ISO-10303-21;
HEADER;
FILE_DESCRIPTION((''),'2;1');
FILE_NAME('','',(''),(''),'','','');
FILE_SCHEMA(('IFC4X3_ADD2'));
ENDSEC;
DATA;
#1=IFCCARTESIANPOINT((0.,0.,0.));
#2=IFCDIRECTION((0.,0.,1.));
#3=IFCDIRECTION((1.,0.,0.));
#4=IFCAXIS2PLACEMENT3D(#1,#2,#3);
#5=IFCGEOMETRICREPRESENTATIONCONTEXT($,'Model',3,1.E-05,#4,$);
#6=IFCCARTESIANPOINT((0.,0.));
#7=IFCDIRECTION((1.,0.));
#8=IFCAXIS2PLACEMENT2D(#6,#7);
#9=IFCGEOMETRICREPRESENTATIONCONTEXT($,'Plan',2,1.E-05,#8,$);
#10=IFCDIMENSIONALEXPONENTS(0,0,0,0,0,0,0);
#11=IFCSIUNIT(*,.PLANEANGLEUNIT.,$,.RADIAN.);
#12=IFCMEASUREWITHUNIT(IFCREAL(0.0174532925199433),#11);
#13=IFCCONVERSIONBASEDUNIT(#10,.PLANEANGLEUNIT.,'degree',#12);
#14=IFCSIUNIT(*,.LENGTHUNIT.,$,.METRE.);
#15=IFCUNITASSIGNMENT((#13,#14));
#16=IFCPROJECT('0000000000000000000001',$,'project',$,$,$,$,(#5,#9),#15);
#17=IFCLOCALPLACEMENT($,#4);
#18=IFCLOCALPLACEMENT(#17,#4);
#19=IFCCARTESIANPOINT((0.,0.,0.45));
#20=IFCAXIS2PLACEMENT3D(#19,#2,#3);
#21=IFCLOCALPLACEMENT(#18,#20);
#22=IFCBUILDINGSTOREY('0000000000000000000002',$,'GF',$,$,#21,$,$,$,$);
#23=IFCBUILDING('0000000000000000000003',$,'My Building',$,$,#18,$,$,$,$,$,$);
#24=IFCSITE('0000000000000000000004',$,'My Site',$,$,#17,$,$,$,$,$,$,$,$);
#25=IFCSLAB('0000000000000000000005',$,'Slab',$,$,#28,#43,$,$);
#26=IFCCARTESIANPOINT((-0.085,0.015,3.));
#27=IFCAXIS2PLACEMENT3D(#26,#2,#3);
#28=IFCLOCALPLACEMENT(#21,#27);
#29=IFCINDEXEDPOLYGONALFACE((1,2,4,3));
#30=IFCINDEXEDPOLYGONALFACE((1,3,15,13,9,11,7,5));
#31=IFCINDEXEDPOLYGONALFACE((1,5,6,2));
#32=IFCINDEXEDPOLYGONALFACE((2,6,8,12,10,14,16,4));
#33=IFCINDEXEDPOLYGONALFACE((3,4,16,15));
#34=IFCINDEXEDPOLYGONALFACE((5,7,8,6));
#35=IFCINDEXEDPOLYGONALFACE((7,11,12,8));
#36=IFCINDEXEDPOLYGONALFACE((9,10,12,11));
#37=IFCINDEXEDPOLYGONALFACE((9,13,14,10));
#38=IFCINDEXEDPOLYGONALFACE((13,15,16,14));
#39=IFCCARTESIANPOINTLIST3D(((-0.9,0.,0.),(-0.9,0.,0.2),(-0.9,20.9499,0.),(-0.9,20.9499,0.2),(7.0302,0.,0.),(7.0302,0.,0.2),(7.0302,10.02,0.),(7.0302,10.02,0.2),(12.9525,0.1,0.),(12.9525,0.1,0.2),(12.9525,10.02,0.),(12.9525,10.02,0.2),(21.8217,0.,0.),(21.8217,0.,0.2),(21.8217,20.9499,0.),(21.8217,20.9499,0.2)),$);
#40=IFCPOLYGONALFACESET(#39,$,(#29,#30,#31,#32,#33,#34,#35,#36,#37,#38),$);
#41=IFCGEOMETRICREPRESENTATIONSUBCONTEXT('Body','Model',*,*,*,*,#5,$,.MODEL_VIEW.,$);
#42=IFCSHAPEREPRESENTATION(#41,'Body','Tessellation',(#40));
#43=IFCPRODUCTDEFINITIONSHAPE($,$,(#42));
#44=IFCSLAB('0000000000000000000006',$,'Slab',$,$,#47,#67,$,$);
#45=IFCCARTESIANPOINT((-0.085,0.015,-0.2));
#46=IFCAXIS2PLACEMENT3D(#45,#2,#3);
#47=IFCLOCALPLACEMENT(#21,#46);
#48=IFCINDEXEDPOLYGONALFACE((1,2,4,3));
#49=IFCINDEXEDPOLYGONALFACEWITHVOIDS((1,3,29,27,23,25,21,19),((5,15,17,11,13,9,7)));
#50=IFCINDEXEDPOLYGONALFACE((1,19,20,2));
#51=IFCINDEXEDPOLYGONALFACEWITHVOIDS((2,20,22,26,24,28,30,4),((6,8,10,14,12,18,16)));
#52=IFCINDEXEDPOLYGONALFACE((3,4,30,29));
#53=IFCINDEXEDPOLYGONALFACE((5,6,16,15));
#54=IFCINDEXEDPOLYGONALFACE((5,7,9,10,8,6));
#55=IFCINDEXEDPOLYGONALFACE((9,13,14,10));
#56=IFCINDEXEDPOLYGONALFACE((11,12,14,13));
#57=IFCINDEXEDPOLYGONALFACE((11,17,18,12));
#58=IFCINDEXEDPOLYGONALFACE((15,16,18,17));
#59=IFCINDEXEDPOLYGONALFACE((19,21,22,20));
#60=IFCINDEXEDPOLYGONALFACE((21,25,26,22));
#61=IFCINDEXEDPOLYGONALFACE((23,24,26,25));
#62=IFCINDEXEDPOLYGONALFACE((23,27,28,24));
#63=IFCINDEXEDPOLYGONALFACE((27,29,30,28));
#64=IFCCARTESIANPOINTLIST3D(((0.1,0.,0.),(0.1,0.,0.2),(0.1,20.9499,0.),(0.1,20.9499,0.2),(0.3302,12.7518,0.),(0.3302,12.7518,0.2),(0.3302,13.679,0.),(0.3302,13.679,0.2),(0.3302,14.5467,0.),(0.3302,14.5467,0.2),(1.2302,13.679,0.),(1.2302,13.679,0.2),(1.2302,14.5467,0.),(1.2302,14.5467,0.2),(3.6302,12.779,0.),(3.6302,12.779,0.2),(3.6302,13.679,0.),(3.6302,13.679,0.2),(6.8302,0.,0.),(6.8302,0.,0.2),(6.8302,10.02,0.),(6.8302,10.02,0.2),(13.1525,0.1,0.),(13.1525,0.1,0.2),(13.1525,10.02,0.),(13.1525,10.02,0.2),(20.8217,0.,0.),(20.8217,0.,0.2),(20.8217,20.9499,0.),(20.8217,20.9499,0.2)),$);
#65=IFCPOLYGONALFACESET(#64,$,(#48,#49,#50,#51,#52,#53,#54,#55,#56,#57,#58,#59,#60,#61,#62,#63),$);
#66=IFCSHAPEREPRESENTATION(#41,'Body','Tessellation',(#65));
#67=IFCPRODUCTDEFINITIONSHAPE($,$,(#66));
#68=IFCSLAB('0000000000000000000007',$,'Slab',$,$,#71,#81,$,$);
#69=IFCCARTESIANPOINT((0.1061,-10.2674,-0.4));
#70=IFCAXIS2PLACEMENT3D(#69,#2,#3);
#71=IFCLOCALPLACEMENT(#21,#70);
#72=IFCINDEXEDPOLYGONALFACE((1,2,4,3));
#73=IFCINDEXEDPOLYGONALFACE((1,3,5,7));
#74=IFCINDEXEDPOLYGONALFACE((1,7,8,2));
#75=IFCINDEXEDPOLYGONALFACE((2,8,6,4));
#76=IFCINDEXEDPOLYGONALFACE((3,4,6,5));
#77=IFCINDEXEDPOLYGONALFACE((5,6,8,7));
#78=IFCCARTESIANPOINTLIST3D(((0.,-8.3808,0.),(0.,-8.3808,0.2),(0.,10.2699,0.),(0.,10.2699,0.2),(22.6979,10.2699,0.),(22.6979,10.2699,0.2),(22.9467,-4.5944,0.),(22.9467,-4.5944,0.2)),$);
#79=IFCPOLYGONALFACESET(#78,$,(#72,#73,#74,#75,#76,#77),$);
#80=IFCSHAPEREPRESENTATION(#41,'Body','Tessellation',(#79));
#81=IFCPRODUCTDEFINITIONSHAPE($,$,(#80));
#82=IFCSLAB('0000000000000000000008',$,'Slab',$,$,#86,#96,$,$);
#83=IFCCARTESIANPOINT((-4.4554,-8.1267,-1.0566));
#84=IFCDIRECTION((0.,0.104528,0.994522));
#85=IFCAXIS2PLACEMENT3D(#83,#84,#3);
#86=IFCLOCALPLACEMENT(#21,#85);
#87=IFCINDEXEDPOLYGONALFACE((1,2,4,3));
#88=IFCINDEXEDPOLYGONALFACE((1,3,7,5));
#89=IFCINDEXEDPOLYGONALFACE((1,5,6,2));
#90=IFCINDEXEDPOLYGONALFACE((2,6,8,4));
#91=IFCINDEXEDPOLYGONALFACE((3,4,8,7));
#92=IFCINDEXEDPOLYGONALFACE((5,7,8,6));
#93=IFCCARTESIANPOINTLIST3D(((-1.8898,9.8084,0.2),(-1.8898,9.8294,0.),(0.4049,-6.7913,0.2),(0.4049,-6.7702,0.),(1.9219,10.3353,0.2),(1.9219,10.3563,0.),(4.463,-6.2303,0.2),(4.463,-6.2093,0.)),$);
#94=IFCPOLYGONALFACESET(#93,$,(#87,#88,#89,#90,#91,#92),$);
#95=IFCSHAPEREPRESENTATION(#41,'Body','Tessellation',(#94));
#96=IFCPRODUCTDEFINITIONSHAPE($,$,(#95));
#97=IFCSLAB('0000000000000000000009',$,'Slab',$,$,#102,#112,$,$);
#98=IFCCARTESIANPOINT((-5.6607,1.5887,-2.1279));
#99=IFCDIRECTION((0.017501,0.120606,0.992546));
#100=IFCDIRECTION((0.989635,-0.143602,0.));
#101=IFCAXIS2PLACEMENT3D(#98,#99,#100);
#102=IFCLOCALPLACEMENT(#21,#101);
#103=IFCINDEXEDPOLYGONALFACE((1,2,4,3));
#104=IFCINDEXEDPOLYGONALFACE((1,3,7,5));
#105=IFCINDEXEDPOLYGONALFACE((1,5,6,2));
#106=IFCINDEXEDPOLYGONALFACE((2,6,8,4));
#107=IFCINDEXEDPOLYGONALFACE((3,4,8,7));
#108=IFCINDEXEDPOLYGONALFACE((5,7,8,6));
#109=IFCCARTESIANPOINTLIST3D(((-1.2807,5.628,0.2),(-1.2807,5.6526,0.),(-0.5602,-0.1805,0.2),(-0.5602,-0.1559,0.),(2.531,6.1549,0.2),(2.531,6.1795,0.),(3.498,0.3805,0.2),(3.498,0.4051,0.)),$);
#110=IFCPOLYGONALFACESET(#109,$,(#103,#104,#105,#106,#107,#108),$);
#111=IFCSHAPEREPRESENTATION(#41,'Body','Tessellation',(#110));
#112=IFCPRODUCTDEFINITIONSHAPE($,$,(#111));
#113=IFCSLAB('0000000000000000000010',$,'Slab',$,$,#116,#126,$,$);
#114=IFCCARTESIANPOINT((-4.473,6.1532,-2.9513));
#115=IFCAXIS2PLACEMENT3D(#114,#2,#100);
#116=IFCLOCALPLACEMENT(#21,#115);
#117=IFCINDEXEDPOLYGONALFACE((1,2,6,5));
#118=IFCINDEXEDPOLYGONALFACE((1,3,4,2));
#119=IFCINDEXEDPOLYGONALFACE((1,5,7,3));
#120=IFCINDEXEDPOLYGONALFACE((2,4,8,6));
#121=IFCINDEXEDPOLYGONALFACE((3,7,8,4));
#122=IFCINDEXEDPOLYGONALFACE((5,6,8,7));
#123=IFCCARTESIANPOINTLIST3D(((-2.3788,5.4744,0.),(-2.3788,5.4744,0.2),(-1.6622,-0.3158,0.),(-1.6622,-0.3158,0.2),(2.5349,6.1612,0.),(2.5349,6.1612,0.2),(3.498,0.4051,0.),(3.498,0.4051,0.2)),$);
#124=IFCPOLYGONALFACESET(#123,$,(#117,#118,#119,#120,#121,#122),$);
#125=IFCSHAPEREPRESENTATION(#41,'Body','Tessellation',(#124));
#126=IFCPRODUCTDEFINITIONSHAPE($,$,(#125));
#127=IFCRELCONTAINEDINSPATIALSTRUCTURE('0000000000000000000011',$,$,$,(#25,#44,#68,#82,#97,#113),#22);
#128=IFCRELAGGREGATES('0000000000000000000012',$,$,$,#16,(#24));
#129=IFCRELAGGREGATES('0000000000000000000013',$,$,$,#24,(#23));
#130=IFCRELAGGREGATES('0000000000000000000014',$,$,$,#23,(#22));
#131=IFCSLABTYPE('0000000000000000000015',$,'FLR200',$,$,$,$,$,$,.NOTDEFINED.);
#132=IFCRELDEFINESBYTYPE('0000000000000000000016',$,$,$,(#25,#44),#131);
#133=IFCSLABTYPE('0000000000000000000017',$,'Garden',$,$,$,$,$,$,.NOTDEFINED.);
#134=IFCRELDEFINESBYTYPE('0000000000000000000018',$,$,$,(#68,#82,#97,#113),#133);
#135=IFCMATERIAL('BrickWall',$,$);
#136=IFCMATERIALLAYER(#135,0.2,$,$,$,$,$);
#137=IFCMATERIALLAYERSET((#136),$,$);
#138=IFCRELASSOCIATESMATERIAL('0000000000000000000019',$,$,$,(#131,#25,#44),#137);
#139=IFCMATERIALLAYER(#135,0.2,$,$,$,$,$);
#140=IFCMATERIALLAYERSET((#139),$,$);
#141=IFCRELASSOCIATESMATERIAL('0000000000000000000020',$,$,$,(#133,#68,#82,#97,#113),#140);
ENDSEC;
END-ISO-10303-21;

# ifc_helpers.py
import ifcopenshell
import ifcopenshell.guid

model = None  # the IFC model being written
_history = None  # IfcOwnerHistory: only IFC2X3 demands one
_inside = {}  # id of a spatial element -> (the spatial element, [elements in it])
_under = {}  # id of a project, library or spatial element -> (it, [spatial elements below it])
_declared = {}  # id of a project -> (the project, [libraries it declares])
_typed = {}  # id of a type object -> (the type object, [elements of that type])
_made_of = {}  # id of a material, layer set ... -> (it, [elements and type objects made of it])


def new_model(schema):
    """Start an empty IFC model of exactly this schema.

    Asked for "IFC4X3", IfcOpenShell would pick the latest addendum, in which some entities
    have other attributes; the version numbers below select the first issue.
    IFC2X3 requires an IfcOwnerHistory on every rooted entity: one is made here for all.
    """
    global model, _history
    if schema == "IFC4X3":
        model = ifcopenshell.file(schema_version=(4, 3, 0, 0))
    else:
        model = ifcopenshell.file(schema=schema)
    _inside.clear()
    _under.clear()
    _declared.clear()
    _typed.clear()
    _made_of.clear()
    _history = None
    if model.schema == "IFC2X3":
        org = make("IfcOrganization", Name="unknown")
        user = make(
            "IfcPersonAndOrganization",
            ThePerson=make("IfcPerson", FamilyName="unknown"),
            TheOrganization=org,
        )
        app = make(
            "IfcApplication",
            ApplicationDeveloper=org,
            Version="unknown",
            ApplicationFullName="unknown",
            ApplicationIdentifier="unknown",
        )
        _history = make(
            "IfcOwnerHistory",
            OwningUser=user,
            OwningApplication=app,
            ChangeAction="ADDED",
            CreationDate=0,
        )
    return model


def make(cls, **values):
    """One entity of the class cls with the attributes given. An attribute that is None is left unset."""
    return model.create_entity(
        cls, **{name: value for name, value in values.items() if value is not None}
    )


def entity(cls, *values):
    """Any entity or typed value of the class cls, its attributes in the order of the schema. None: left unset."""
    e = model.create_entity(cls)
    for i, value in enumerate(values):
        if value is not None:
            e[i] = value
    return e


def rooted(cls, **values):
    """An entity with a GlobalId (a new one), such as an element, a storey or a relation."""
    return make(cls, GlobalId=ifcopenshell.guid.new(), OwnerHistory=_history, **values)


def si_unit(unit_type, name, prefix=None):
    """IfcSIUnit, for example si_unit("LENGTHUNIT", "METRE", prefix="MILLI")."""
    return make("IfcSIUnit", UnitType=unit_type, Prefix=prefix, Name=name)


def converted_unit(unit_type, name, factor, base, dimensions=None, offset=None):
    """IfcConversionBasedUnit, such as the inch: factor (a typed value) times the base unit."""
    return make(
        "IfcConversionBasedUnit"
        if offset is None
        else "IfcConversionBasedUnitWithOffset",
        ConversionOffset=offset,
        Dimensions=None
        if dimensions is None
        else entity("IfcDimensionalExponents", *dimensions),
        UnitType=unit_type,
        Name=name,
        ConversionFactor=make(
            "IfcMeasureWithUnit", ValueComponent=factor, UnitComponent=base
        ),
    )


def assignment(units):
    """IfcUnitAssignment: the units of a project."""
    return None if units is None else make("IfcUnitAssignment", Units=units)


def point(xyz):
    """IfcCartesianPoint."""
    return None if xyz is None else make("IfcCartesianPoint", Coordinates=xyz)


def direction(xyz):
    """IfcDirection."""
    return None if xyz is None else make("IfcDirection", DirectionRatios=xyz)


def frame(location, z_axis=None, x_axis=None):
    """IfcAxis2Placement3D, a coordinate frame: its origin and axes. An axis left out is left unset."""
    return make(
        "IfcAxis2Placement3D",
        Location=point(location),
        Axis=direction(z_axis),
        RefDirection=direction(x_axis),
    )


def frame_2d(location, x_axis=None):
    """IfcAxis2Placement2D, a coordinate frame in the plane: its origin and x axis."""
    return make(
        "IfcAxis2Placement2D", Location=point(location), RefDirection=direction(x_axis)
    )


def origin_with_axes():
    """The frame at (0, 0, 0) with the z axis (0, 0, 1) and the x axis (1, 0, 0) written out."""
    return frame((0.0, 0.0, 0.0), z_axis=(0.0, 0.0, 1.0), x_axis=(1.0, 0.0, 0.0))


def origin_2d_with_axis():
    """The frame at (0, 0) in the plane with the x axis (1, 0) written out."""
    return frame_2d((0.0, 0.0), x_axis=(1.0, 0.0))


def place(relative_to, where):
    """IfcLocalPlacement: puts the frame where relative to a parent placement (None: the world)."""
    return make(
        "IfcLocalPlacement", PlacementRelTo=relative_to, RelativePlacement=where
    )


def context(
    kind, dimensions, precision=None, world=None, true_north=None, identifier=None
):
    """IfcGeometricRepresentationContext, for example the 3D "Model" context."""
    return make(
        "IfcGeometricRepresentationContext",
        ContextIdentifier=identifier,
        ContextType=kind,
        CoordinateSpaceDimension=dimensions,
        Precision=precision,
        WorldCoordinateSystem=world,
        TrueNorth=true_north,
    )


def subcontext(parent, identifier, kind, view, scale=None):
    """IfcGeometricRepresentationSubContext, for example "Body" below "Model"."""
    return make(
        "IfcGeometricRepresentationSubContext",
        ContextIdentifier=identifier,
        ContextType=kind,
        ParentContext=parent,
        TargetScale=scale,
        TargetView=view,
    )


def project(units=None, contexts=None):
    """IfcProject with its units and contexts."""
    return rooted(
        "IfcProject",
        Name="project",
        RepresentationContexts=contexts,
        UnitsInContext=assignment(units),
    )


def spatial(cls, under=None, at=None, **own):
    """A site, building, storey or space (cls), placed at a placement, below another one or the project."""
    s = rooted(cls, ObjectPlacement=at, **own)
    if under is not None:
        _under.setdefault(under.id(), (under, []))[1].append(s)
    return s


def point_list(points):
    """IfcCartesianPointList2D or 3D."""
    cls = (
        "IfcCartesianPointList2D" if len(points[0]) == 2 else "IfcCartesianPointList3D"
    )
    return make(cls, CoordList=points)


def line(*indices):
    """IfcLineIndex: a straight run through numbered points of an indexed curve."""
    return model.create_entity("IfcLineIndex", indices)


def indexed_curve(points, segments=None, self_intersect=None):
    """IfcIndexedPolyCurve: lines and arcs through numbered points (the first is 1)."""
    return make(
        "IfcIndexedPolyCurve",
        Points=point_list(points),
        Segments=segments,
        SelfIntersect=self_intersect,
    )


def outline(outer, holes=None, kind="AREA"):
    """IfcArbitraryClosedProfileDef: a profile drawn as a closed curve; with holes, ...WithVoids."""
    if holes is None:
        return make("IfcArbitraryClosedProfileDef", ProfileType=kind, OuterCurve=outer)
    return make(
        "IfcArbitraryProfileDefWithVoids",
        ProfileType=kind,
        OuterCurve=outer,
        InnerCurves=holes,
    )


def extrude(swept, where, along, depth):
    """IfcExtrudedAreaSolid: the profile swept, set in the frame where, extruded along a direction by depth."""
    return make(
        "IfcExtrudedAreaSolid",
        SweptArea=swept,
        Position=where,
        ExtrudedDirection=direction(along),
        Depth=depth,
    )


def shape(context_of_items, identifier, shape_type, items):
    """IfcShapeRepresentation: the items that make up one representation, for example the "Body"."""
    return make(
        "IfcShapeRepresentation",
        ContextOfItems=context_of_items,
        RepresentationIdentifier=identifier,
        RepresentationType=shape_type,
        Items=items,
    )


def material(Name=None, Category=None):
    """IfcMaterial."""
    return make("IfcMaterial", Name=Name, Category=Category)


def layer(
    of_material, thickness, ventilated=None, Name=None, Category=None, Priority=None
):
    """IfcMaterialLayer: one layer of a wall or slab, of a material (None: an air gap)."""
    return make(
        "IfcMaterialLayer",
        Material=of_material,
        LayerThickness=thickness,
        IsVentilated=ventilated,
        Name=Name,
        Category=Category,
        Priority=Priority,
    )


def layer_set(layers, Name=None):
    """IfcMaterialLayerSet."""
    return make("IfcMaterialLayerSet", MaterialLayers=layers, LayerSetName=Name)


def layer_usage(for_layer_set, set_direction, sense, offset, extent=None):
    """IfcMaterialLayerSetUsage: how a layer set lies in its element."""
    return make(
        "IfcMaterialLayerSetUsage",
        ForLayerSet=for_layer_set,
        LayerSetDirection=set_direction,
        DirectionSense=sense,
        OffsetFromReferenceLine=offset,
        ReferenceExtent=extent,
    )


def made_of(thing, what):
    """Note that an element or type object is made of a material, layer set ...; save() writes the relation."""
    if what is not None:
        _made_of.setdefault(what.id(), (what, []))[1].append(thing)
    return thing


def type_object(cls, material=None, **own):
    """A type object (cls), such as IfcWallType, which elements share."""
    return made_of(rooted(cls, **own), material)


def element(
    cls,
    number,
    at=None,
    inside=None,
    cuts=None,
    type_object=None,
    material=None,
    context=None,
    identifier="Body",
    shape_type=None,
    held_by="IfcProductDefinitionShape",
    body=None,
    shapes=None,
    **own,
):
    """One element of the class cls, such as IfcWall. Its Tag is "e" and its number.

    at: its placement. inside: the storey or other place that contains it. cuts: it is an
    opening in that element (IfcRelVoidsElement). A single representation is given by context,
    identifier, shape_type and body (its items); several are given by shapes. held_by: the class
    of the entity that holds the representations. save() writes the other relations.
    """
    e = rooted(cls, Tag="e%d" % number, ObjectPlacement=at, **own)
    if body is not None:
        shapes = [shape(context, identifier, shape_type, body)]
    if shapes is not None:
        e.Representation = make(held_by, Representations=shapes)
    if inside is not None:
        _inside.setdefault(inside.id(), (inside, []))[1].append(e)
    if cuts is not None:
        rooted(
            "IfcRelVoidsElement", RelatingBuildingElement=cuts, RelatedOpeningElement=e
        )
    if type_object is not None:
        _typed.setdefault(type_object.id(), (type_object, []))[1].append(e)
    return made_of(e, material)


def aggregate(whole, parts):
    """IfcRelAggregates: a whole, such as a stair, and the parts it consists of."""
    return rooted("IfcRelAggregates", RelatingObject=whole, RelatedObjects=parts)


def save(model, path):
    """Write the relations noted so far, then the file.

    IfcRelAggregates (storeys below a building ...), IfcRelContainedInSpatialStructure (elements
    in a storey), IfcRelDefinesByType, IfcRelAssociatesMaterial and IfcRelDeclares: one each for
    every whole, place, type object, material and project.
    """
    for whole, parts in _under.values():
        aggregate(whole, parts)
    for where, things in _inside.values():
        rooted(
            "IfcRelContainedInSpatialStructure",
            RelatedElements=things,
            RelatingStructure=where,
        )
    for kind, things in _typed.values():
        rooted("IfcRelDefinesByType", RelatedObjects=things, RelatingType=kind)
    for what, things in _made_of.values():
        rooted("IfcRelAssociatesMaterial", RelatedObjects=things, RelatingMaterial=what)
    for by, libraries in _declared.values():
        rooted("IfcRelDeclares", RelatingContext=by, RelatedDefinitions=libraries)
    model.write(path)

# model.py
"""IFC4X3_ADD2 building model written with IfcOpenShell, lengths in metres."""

from ifc_helpers import new_model, entity, si_unit, converted_unit, frame, origin_with_axes, origin_2d_with_axis, place, context, subcontext, project, spatial, line, indexed_curve, outline, extrude, material, layer, layer_set, layer_usage, type_object, element, save


model = new_model("IFC4X3_ADD2")

# Units and contexts
model_context = context("Model", 3, precision=1e-05, world=origin_with_axes())
plan_context = context("Plan", 2, precision=1e-05, world=origin_2d_with_axis())
body_context_1 = subcontext(model_context, "Body", "Model", "MODEL_VIEW")
ifc_project = project(units=[converted_unit("PLANEANGLEUNIT", "degree", entity("IfcReal", 0.0174532925199433), si_unit("PLANEANGLEUNIT", "RADIAN"), dimensions=[0, 0, 0, 0, 0, 0, 0]), si_unit("LENGTHUNIT", "METRE")], contexts=[model_context, plan_context])

# Site, building, storey
site_placement = place(None, origin_with_axes())
site = spatial("IfcSite", under=ifc_project, at=site_placement, Name="My Site")
building_placement = place(site_placement, origin_with_axes())
building = spatial("IfcBuilding", under=site, at=building_placement, Name="My Building")
storey_placement = place(building_placement, frame((0.0, 0.0, 0.45), z_axis=(0.0, 0.0, 1.0), x_axis=(1.0, 0.0, 0.0)))
storey = spatial("IfcBuildingStorey", under=building, at=storey_placement, Name="GF")

# Slabs
ifc_material = material(Name="BrickWall")
ifc_layer_1 = layer(ifc_material, 0.2)
ifc_layer_set_1 = layer_set([ifc_layer_1])
ifc_layer_usage_1 = layer_usage(ifc_layer_set_1, "AXIS3", "POSITIVE", 0.0)
slab_type_1 = type_object("IfcSlabType", Name="FLR200", PredefinedType="NOTDEFINED", material=ifc_layer_set_1)
slab_1_placement = place(storey_placement, frame((-0.085, 0.015, 3.0), z_axis=(0.0, 0.0, 1.0), x_axis=(1.0, 0.0, 0.0)))
element("IfcSlab", 1, at=slab_1_placement, inside=storey, type_object=slab_type_1, material=ifc_layer_usage_1, Name="Slab", context=body_context_1, shape_type="SweptSolid", body=[
    extrude(outline(indexed_curve([(-0.9, 0.0), (7.0302, 0.0), (7.0302, 10.02), (12.9525, 10.02), (12.9525, 0.1), (21.8217, 0.0), (21.8217, 20.9499), (-0.9, 20.9499)], segments=[line(5, 4), line(4, 3), line(3, 2), line(2, 1), line(1, 8), line(8, 7), line(7, 6), line(6, 5)], self_intersect=False)), None, (0.0, 0.0, 1.0), 0.2),
])
ifc_layer_usage_2 = layer_usage(ifc_layer_set_1, "AXIS3", "POSITIVE", 0.0)
slab_2_placement = place(storey_placement, frame((-0.085, 0.015, -0.2), z_axis=(0.0, 0.0, 1.0), x_axis=(1.0, 0.0, 0.0)))
element("IfcSlab", 2, at=slab_2_placement, inside=storey, type_object=slab_type_1, material=ifc_layer_usage_2, Name="Slab", context=body_context_1, shape_type="SweptSolid", body=[
    extrude(outline(indexed_curve([(0.1, 20.9499), (20.8217, 20.9499), (20.8217, 0.0), (13.1525, 0.1), (13.1525, 10.02), (6.8302, 10.02), (6.8302, 0.0), (0.1, 0.0), (1.2302, 13.679), (1.2302, 14.5467), (0.3302, 14.5467), (0.3302, 13.679), (0.3302, 12.7518), (3.6302, 12.779), (3.6302, 13.679)], segments=[line(6, 7), line(7, 8), line(8, 1), line(1, 2), line(2, 3), line(3, 4), line(4, 5), line(5, 6)], self_intersect=False), holes=[indexed_curve([(0.1, 20.9499), (20.8217, 20.9499), (20.8217, 0.0), (13.1525, 0.1), (13.1525, 10.02), (6.8302, 10.02), (6.8302, 0.0), (0.1, 0.0), (1.2302, 13.679), (1.2302, 14.5467), (0.3302, 14.5467), (0.3302, 13.679), (0.3302, 12.7518), (3.6302, 12.779), (3.6302, 13.679)], segments=[line(13, 12), line(12, 11), line(11, 10), line(10, 9), line(9, 15), line(15, 14), line(14, 13)], self_intersect=False)]), None, (0.0, 0.0, 1.0), 0.2),
])
ifc_layer_2 = layer(ifc_material, 0.2)
ifc_layer_set_2 = layer_set([ifc_layer_2])
ifc_layer_usage_3 = layer_usage(ifc_layer_set_2, "AXIS3", "POSITIVE", 0.0)
slab_type_2 = type_object("IfcSlabType", Name="Garden", PredefinedType="NOTDEFINED", material=ifc_layer_set_2)
slab_3_placement = place(storey_placement, frame((0.1061, -10.2674, -0.4), z_axis=(0.0, 0.0, 1.0), x_axis=(1.0, 0.0, 0.0)))
element("IfcSlab", 3, at=slab_3_placement, inside=storey, type_object=slab_type_2, material=ifc_layer_usage_3, Name="Slab", context=body_context_1, shape_type="SweptSolid", body=[
    extrude(outline(indexed_curve([(0.0, -8.3808), (22.9467, -4.5944), (22.6979, 10.2699), (0.0, 10.2699)], segments=[line(4, 1), line(1, 2), line(2, 3), line(3, 4)], self_intersect=False)), None, (0.0, 0.0, 1.0), 0.2),
])
ifc_layer_usage_4 = layer_usage(ifc_layer_set_2, "AXIS3", "POSITIVE", 0.0)
slab_4_placement = place(storey_placement, frame((-4.4554, -8.1267, -1.0566), z_axis=(0.0, 0.104528, 0.994522), x_axis=(1.0, 0.0, 0.0)))
element("IfcSlab", 4, at=slab_4_placement, inside=storey, type_object=slab_type_2, material=ifc_layer_usage_4, Name="Slab", context=body_context_1, shape_type="SweptSolid", body=[
    extrude(outline(indexed_curve([(-1.8898, 9.8294), (1.9219, 10.3563), (4.463, -6.2093), (0.4049, -6.7702)], segments=[line(4, 1), line(1, 2), line(2, 3), line(3, 4)], self_intersect=False)), None, (0.0, -0.104528, 0.994522), 0.2011),
])
ifc_layer_usage_5 = layer_usage(ifc_layer_set_2, "AXIS3", "POSITIVE", 0.0)
slab_5_placement = place(storey_placement, frame((-5.6607, 1.5887, -2.1279), z_axis=(0.017501, 0.120606, 0.992546), x_axis=(0.989635, -0.143602, 0.0)))
element("IfcSlab", 5, at=slab_5_placement, inside=storey, type_object=slab_type_2, material=ifc_layer_usage_5, Name="Slab", context=body_context_1, shape_type="SweptSolid", body=[
    extrude(outline(indexed_curve([(-1.2807, 5.6526), (2.531, 6.1795), (3.498, 0.4051), (-0.5602, -0.1559)], segments=[line(4, 1), line(1, 2), line(2, 3), line(3, 4)], self_intersect=False)), None, (0.0, -0.121869, 0.992546), 0.2015),
])
ifc_layer_usage_6 = layer_usage(ifc_layer_set_2, "AXIS3", "POSITIVE", 0.0)
slab_6_placement = place(storey_placement, frame((-4.473, 6.1532, -2.9513), z_axis=(0.0, 0.0, 1.0), x_axis=(0.989635, -0.143602, 0.0)))
element("IfcSlab", 6, at=slab_6_placement, inside=storey, type_object=slab_type_2, material=ifc_layer_usage_6, Name="Slab", context=body_context_1, shape_type="SweptSolid", body=[
    extrude(outline(indexed_curve([(-2.3788, 5.4744), (2.5349, 6.1612), (3.498, 0.4051), (-1.6622, -0.3158)], segments=[line(3, 2), line(2, 1), line(1, 4), line(4, 3)], self_intersect=False)), None, (0.0, 0.0, 1.0), 0.2),
])

save(model, "model.ifc")
